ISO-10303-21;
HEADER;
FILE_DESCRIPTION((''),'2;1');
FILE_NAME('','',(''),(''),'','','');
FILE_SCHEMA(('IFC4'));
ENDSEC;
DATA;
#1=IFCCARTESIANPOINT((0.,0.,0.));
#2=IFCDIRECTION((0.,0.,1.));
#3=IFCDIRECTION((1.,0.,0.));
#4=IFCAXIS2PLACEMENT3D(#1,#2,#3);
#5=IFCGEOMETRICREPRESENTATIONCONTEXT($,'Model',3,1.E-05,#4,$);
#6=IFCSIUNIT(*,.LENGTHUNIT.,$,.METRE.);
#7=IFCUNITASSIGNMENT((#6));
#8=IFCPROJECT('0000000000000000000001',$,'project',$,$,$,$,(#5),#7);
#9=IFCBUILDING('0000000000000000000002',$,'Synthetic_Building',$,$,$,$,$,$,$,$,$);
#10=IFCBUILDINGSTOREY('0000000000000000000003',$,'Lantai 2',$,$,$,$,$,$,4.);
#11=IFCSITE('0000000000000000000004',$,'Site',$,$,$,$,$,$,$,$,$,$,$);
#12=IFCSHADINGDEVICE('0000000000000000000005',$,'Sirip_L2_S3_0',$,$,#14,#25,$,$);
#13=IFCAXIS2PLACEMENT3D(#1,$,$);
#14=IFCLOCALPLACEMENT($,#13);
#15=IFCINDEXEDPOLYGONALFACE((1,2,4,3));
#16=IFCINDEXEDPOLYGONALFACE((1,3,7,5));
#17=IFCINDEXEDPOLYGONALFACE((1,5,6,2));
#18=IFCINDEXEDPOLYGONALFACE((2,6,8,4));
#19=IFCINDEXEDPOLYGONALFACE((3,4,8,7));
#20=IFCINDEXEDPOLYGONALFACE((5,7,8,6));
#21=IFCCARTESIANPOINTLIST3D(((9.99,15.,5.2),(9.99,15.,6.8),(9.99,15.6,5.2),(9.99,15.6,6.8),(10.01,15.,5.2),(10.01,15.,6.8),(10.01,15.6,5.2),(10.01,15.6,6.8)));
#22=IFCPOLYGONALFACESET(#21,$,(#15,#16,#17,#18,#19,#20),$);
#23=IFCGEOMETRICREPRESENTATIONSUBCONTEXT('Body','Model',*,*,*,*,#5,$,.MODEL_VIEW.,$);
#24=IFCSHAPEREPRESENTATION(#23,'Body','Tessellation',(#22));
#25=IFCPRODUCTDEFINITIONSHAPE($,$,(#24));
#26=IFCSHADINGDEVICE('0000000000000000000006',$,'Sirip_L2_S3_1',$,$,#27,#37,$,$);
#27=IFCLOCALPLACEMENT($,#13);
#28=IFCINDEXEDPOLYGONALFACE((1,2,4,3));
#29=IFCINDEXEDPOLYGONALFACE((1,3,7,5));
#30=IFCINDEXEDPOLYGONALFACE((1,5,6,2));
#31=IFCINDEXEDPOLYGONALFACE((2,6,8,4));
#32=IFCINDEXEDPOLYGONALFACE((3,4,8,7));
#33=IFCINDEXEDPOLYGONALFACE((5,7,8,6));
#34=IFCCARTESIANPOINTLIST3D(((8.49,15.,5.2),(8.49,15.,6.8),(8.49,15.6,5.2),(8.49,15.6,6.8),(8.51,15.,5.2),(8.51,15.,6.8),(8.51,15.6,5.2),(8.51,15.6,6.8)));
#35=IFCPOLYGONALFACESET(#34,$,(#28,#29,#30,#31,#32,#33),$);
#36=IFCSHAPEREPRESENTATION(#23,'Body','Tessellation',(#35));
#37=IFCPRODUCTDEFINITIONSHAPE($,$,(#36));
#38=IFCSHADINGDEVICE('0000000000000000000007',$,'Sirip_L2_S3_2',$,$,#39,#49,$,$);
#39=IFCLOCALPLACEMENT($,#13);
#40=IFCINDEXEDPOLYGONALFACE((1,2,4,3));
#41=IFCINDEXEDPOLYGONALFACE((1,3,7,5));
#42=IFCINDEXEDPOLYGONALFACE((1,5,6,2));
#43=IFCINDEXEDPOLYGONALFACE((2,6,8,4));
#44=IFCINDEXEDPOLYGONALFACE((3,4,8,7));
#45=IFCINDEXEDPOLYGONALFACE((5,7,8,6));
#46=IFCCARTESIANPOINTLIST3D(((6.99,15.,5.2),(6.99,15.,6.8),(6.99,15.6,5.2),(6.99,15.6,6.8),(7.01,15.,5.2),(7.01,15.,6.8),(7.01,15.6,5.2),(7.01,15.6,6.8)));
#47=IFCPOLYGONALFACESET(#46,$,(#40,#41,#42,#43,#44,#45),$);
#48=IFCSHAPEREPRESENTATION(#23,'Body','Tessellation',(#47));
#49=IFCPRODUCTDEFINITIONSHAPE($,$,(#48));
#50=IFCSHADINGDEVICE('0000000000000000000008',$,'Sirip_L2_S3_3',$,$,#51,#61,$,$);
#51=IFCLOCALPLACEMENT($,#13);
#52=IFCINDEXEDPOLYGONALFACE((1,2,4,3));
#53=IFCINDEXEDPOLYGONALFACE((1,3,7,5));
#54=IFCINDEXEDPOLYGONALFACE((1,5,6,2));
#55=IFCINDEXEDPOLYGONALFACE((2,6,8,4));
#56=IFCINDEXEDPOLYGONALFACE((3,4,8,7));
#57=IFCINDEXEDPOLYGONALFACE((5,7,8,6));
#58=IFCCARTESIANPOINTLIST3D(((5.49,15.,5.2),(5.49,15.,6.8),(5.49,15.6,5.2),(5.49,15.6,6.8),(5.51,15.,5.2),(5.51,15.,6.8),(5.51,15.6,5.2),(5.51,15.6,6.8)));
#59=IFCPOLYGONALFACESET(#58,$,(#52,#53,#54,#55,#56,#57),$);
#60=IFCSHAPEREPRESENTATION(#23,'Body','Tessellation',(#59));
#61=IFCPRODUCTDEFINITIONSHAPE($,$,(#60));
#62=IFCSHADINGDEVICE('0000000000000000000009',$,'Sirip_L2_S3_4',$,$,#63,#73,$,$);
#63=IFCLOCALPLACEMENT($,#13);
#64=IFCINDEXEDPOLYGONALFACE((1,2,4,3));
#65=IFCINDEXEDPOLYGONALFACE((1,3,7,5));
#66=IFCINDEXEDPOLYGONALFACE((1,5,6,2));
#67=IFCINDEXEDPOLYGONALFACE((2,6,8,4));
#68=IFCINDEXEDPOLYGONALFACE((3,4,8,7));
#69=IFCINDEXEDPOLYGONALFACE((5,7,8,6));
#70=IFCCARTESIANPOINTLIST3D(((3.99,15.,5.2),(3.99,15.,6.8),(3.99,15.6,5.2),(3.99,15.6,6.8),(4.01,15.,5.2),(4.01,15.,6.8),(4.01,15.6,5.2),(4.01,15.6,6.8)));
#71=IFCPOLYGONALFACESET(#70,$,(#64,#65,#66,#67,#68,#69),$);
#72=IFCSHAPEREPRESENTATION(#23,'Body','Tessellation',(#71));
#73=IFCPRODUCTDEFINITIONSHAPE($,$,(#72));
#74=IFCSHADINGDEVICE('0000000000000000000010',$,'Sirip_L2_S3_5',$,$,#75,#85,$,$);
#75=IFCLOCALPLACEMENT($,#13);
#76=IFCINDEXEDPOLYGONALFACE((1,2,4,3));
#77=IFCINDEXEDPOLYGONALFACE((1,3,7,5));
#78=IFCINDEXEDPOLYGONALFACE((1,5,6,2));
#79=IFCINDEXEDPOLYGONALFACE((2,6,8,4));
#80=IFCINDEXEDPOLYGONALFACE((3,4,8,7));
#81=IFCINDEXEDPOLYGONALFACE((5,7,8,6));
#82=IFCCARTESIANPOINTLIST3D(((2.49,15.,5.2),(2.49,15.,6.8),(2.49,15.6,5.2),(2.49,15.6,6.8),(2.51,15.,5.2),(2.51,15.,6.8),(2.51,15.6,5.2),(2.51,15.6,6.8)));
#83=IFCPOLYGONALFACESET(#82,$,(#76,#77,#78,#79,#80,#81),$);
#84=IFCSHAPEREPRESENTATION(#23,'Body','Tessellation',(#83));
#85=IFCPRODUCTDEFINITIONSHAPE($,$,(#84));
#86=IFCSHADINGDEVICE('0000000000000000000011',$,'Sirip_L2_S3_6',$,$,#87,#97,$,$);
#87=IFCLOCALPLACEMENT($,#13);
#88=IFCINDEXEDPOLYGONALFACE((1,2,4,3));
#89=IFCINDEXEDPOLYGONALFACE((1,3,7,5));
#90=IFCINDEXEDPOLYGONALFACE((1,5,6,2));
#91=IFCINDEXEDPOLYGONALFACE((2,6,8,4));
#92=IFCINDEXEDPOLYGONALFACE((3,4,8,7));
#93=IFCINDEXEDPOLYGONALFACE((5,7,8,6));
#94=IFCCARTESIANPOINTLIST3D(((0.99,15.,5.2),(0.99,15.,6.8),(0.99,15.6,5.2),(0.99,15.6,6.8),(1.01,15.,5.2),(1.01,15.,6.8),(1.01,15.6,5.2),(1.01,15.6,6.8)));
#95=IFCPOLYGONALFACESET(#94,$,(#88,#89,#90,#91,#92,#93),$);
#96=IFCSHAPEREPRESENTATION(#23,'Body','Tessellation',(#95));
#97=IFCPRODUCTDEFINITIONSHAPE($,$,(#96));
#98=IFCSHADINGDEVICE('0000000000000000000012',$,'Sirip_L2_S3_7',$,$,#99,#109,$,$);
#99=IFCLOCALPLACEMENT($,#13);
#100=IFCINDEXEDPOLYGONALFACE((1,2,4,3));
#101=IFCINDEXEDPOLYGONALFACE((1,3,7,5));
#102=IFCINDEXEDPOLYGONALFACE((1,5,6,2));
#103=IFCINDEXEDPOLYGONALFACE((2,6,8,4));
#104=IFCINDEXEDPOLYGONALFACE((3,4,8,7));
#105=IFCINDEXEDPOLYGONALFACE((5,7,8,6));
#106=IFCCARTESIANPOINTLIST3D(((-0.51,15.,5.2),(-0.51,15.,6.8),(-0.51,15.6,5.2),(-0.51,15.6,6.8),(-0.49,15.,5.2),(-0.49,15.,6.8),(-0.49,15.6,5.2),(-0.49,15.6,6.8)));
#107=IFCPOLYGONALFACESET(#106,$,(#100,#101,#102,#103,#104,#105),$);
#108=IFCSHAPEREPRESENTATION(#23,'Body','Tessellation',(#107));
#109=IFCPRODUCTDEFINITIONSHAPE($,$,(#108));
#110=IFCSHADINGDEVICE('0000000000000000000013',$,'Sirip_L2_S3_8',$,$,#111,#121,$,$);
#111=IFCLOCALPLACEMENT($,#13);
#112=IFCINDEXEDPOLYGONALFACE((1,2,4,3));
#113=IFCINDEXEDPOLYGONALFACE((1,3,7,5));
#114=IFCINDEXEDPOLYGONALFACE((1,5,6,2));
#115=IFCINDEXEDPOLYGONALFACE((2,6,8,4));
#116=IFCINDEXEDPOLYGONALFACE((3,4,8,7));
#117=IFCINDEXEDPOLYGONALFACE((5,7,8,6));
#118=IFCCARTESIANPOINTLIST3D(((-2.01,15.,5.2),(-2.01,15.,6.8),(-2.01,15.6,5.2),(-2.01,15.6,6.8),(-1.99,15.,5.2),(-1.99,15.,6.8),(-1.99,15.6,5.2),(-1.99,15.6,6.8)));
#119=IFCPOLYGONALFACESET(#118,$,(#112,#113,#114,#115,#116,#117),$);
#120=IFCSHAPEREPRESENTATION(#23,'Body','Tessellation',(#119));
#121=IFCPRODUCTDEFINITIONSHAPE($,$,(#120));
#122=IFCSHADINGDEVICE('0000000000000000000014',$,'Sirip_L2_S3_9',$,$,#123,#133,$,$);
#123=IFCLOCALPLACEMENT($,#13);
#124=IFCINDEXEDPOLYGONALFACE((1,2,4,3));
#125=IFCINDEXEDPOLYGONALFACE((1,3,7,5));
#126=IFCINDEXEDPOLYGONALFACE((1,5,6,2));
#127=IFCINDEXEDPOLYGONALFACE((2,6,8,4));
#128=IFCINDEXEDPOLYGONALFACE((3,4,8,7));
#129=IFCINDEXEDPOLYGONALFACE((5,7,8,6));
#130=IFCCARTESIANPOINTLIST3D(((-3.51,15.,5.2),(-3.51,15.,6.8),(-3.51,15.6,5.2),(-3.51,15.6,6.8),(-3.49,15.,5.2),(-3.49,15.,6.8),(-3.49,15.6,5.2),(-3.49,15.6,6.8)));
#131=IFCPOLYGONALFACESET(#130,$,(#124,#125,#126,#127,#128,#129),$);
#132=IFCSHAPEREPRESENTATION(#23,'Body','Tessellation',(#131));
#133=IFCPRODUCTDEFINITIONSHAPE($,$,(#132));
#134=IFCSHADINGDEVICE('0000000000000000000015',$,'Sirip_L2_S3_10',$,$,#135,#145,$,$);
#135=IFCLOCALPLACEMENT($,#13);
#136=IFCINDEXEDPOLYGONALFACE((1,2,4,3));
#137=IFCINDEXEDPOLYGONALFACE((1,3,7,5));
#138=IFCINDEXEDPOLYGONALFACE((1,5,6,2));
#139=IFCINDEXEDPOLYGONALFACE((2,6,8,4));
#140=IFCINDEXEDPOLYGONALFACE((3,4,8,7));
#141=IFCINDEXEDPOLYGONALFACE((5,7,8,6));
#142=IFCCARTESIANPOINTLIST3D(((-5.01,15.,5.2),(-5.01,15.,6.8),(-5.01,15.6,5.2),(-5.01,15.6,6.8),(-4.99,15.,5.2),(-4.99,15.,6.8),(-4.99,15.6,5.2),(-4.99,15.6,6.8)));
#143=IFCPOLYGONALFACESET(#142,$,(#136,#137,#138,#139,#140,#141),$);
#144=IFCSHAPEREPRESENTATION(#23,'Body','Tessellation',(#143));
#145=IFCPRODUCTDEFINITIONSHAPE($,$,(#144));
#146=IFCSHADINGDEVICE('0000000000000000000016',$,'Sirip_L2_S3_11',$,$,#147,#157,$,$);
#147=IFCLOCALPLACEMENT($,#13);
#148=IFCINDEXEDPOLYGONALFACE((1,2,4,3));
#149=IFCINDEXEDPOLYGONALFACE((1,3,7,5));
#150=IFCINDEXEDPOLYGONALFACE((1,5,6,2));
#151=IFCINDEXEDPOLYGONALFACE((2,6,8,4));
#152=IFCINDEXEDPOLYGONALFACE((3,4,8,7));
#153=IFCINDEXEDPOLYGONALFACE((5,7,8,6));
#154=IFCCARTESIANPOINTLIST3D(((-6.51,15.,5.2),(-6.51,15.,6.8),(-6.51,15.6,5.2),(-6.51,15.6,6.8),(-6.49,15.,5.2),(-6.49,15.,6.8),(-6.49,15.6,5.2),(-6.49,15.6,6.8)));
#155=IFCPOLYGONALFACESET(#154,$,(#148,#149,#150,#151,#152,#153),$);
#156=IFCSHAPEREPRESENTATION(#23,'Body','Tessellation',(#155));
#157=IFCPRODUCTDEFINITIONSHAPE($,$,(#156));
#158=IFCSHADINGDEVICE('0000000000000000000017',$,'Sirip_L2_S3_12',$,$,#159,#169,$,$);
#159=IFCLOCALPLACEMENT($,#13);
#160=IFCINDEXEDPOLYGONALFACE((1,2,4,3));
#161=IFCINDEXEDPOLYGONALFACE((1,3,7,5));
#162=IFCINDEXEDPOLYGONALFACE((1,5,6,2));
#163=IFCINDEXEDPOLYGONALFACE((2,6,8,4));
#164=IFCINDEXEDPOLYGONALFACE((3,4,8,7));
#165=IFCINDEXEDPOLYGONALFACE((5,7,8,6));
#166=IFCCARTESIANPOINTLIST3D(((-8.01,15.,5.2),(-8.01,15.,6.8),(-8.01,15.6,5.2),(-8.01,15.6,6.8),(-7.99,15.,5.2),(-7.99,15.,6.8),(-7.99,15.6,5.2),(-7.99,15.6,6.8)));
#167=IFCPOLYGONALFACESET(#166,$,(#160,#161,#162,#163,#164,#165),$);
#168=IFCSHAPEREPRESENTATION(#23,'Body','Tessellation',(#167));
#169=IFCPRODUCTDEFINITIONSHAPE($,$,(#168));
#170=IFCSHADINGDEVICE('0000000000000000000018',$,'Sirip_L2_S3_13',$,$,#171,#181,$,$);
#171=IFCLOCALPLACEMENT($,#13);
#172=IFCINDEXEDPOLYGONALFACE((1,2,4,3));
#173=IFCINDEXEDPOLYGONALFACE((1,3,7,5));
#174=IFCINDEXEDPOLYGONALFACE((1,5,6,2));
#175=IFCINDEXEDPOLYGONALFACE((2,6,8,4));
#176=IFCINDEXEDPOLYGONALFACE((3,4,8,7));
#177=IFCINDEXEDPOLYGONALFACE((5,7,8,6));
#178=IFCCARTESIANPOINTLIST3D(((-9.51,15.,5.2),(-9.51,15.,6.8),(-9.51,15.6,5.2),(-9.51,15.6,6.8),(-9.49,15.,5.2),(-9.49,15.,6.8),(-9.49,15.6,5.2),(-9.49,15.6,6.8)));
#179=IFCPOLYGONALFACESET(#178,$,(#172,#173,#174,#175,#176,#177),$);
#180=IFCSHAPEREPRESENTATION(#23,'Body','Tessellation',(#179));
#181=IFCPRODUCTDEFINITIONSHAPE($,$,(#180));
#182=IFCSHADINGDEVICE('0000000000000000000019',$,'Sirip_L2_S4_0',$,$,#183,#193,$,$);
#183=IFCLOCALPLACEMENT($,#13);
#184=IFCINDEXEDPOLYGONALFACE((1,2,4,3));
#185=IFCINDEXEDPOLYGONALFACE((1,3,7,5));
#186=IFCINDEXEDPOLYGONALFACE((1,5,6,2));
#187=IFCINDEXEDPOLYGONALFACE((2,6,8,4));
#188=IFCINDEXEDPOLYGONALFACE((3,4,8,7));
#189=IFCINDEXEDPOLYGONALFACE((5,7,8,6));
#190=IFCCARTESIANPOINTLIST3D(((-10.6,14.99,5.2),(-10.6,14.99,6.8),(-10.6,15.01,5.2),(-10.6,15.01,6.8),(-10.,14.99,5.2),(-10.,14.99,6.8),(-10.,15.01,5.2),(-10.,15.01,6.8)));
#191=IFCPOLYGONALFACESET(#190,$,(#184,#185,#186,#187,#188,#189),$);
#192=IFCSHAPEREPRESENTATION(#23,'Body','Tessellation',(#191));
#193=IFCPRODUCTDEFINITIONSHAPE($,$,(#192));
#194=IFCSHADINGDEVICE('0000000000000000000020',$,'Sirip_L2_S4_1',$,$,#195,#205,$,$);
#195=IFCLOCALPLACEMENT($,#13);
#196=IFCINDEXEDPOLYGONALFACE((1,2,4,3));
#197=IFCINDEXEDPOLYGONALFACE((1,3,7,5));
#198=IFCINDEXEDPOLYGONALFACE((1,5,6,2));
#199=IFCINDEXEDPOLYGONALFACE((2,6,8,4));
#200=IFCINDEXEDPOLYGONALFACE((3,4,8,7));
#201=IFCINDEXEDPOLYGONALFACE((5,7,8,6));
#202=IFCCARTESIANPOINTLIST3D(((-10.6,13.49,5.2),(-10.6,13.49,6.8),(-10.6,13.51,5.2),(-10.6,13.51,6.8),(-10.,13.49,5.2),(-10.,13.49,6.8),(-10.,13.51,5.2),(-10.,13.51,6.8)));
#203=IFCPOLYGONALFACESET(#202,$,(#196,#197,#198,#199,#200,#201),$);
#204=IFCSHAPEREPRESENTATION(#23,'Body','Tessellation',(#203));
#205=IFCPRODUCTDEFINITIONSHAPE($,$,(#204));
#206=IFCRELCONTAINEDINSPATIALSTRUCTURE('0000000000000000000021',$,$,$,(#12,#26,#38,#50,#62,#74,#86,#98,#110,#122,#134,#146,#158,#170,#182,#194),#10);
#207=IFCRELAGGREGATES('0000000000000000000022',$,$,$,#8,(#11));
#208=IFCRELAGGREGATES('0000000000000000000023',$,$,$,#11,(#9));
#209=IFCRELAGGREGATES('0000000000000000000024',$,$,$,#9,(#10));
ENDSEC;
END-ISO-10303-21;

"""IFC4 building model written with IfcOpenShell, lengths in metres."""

from ifc_helpers import new_model, si_unit, frame, origin_with_axes, place, context, subcontext, project, spatial, polyline, outline, extrude, element, save


model = new_model("IFC4")

# Units and contexts
model_context = context("Model", 3, precision=1e-05, world=origin_with_axes())
body_context = subcontext(model_context, "Body", "Model", "MODEL_VIEW")
ifc_project = project(units=[si_unit("LENGTHUNIT", "METRE")], contexts=[model_context])

# Site, building, storey
site = spatial("IfcSite", under=ifc_project, Name="Site")
building = spatial("IfcBuilding", under=site, Name="Synthetic_Building")
storey = spatial("IfcBuildingStorey", under=building, Name="Lantai 2", Elevation=4.0)

# Shading devices
shading_device_1_placement = place(None, origin_with_axes())
element("IfcShadingDevice", 1, at=shading_device_1_placement, inside=storey, Name="Sirip_L2_S3_0", context=body_context, shape_type="SweptSolid", body=[
    extrude(outline(polyline([(10.01, 15.0), (9.99, 15.0), (9.99, 15.6), (10.01, 15.6), (10.01, 15.0)])), frame((0.0, 0.0, 5.2), z_axis=(0.0, 0.0, 1.0), x_axis=(1.0, 0.0, 0.0)), (0.0, 0.0, 1.0), 1.6),
])
shading_device_2_placement = place(None, origin_with_axes())
element("IfcShadingDevice", 2, at=shading_device_2_placement, inside=storey, Name="Sirip_L2_S3_1", context=body_context, shape_type="SweptSolid", body=[
    extrude(outline(polyline([(8.51, 15.0), (8.49, 15.0), (8.49, 15.6), (8.51, 15.6), (8.51, 15.0)])), frame((0.0, 0.0, 5.2), z_axis=(0.0, 0.0, 1.0), x_axis=(1.0, 0.0, 0.0)), (0.0, 0.0, 1.0), 1.6),
])
shading_device_3_placement = place(None, origin_with_axes())
element("IfcShadingDevice", 3, at=shading_device_3_placement, inside=storey, Name="Sirip_L2_S3_2", context=body_context, shape_type="SweptSolid", body=[
    extrude(outline(polyline([(7.01, 15.0), (6.99, 15.0), (6.99, 15.6), (7.01, 15.6), (7.01, 15.0)])), frame((0.0, 0.0, 5.2), z_axis=(0.0, 0.0, 1.0), x_axis=(1.0, 0.0, 0.0)), (0.0, 0.0, 1.0), 1.6),
])
shading_device_4_placement = place(None, origin_with_axes())
element("IfcShadingDevice", 4, at=shading_device_4_placement, inside=storey, Name="Sirip_L2_S3_3", context=body_context, shape_type="SweptSolid", body=[
    extrude(outline(polyline([(5.51, 15.0), (5.49, 15.0), (5.49, 15.6), (5.51, 15.6), (5.51, 15.0)])), frame((0.0, 0.0, 5.2), z_axis=(0.0, 0.0, 1.0), x_axis=(1.0, 0.0, 0.0)), (0.0, 0.0, 1.0), 1.6),
])
shading_device_5_placement = place(None, origin_with_axes())
element("IfcShadingDevice", 5, at=shading_device_5_placement, inside=storey, Name="Sirip_L2_S3_4", context=body_context, shape_type="SweptSolid", body=[
    extrude(outline(polyline([(4.01, 15.0), (3.99, 15.0), (3.99, 15.6), (4.01, 15.6), (4.01, 15.0)])), frame((0.0, 0.0, 5.2), z_axis=(0.0, 0.0, 1.0), x_axis=(1.0, 0.0, 0.0)), (0.0, 0.0, 1.0), 1.6),
])
shading_device_6_placement = place(None, origin_with_axes())
element("IfcShadingDevice", 6, at=shading_device_6_placement, inside=storey, Name="Sirip_L2_S3_5", context=body_context, shape_type="SweptSolid", body=[
    extrude(outline(polyline([(2.51, 15.0), (2.49, 15.0), (2.49, 15.6), (2.51, 15.6), (2.51, 15.0)])), frame((0.0, 0.0, 5.2), z_axis=(0.0, 0.0, 1.0), x_axis=(1.0, 0.0, 0.0)), (0.0, 0.0, 1.0), 1.6),
])
shading_device_7_placement = place(None, origin_with_axes())
element("IfcShadingDevice", 7, at=shading_device_7_placement, inside=storey, Name="Sirip_L2_S3_6", context=body_context, shape_type="SweptSolid", body=[
    extrude(outline(polyline([(1.01, 15.0), (0.99, 15.0), (0.99, 15.6), (1.01, 15.6), (1.01, 15.0)])), frame((0.0, 0.0, 5.2), z_axis=(0.0, 0.0, 1.0), x_axis=(1.0, 0.0, 0.0)), (0.0, 0.0, 1.0), 1.6),
])
shading_device_8_placement = place(None, origin_with_axes())
element("IfcShadingDevice", 8, at=shading_device_8_placement, inside=storey, Name="Sirip_L2_S3_7", context=body_context, shape_type="SweptSolid", body=[
    extrude(outline(polyline([(-0.49, 15.0), (-0.51, 15.0), (-0.51, 15.6), (-0.49, 15.6), (-0.49, 15.0)])), frame((0.0, 0.0, 5.2), z_axis=(0.0, 0.0, 1.0), x_axis=(1.0, 0.0, 0.0)), (0.0, 0.0, 1.0), 1.6),
])
shading_device_9_placement = place(None, origin_with_axes())
element("IfcShadingDevice", 9, at=shading_device_9_placement, inside=storey, Name="Sirip_L2_S3_8", context=body_context, shape_type="SweptSolid", body=[
    extrude(outline(polyline([(-1.99, 15.0), (-2.01, 15.0), (-2.01, 15.6), (-1.99, 15.6), (-1.99, 15.0)])), frame((0.0, 0.0, 5.2), z_axis=(0.0, 0.0, 1.0), x_axis=(1.0, 0.0, 0.0)), (0.0, 0.0, 1.0), 1.6),
])
shading_device_10_placement = place(None, origin_with_axes())
element("IfcShadingDevice", 10, at=shading_device_10_placement, inside=storey, Name="Sirip_L2_S3_9", context=body_context, shape_type="SweptSolid", body=[
    extrude(outline(polyline([(-3.49, 15.0), (-3.51, 15.0), (-3.51, 15.6), (-3.49, 15.6), (-3.49, 15.0)])), frame((0.0, 0.0, 5.2), z_axis=(0.0, 0.0, 1.0), x_axis=(1.0, 0.0, 0.0)), (0.0, 0.0, 1.0), 1.6),
])
shading_device_11_placement = place(None, origin_with_axes())
element("IfcShadingDevice", 11, at=shading_device_11_placement, inside=storey, Name="Sirip_L2_S3_10", context=body_context, shape_type="SweptSolid", body=[
    extrude(outline(polyline([(-4.99, 15.0), (-5.01, 15.0), (-5.01, 15.6), (-4.99, 15.6), (-4.99, 15.0)])), frame((0.0, 0.0, 5.2), z_axis=(0.0, 0.0, 1.0), x_axis=(1.0, 0.0, 0.0)), (0.0, 0.0, 1.0), 1.6),
])
shading_device_12_placement = place(None, origin_with_axes())
element("IfcShadingDevice", 12, at=shading_device_12_placement, inside=storey, Name="Sirip_L2_S3_11", context=body_context, shape_type="SweptSolid", body=[
    extrude(outline(polyline([(-6.49, 15.0), (-6.51, 15.0), (-6.51, 15.6), (-6.49, 15.6), (-6.49, 15.0)])), frame((0.0, 0.0, 5.2), z_axis=(0.0, 0.0, 1.0), x_axis=(1.0, 0.0, 0.0)), (0.0, 0.0, 1.0), 1.6),
])
shading_device_13_placement = place(None, origin_with_axes())
element("IfcShadingDevice", 13, at=shading_device_13_placement, inside=storey, Name="Sirip_L2_S3_12", context=body_context, shape_type="SweptSolid", body=[
    extrude(outline(polyline([(-7.99, 15.0), (-8.01, 15.0), (-8.01, 15.6), (-7.99, 15.6), (-7.99, 15.0)])), frame((0.0, 0.0, 5.2), z_axis=(0.0, 0.0, 1.0), x_axis=(1.0, 0.0, 0.0)), (0.0, 0.0, 1.0), 1.6),
])
shading_device_14_placement = place(None, origin_with_axes())
element("IfcShadingDevice", 14, at=shading_device_14_placement, inside=storey, Name="Sirip_L2_S3_13", context=body_context, shape_type="SweptSolid", body=[
    extrude(outline(polyline([(-9.49, 15.0), (-9.51, 15.0), (-9.51, 15.6), (-9.49, 15.6), (-9.49, 15.0)])), frame((0.0, 0.0, 5.2), z_axis=(0.0, 0.0, 1.0), x_axis=(1.0, 0.0, 0.0)), (0.0, 0.0, 1.0), 1.6),
])
shading_device_15_placement = place(None, origin_with_axes())
element("IfcShadingDevice", 15, at=shading_device_15_placement, inside=storey, Name="Sirip_L2_S4_0", context=body_context, shape_type="SweptSolid", body=[
    extrude(outline(polyline([(-10.0, 15.01), (-10.0, 14.99), (-10.6, 14.99), (-10.6, 15.01), (-10.0, 15.01)])), frame((0.0, 0.0, 5.2), z_axis=(0.0, 0.0, 1.0), x_axis=(1.0, 0.0, 0.0)), (0.0, 0.0, 1.0), 1.6),
])
shading_device_16_placement = place(None, origin_with_axes())
element("IfcShadingDevice", 16, at=shading_device_16_placement, inside=storey, Name="Sirip_L2_S4_1", context=body_context, shape_type="SweptSolid", body=[
    extrude(outline(polyline([(-10.0, 13.51), (-10.0, 13.49), (-10.6, 13.49), (-10.6, 13.51), (-10.0, 13.51)])), frame((0.0, 0.0, 5.2), z_axis=(0.0, 0.0, 1.0), x_axis=(1.0, 0.0, 0.0)), (0.0, 0.0, 1.0), 1.6),
])

save(model, "model.ifc")
